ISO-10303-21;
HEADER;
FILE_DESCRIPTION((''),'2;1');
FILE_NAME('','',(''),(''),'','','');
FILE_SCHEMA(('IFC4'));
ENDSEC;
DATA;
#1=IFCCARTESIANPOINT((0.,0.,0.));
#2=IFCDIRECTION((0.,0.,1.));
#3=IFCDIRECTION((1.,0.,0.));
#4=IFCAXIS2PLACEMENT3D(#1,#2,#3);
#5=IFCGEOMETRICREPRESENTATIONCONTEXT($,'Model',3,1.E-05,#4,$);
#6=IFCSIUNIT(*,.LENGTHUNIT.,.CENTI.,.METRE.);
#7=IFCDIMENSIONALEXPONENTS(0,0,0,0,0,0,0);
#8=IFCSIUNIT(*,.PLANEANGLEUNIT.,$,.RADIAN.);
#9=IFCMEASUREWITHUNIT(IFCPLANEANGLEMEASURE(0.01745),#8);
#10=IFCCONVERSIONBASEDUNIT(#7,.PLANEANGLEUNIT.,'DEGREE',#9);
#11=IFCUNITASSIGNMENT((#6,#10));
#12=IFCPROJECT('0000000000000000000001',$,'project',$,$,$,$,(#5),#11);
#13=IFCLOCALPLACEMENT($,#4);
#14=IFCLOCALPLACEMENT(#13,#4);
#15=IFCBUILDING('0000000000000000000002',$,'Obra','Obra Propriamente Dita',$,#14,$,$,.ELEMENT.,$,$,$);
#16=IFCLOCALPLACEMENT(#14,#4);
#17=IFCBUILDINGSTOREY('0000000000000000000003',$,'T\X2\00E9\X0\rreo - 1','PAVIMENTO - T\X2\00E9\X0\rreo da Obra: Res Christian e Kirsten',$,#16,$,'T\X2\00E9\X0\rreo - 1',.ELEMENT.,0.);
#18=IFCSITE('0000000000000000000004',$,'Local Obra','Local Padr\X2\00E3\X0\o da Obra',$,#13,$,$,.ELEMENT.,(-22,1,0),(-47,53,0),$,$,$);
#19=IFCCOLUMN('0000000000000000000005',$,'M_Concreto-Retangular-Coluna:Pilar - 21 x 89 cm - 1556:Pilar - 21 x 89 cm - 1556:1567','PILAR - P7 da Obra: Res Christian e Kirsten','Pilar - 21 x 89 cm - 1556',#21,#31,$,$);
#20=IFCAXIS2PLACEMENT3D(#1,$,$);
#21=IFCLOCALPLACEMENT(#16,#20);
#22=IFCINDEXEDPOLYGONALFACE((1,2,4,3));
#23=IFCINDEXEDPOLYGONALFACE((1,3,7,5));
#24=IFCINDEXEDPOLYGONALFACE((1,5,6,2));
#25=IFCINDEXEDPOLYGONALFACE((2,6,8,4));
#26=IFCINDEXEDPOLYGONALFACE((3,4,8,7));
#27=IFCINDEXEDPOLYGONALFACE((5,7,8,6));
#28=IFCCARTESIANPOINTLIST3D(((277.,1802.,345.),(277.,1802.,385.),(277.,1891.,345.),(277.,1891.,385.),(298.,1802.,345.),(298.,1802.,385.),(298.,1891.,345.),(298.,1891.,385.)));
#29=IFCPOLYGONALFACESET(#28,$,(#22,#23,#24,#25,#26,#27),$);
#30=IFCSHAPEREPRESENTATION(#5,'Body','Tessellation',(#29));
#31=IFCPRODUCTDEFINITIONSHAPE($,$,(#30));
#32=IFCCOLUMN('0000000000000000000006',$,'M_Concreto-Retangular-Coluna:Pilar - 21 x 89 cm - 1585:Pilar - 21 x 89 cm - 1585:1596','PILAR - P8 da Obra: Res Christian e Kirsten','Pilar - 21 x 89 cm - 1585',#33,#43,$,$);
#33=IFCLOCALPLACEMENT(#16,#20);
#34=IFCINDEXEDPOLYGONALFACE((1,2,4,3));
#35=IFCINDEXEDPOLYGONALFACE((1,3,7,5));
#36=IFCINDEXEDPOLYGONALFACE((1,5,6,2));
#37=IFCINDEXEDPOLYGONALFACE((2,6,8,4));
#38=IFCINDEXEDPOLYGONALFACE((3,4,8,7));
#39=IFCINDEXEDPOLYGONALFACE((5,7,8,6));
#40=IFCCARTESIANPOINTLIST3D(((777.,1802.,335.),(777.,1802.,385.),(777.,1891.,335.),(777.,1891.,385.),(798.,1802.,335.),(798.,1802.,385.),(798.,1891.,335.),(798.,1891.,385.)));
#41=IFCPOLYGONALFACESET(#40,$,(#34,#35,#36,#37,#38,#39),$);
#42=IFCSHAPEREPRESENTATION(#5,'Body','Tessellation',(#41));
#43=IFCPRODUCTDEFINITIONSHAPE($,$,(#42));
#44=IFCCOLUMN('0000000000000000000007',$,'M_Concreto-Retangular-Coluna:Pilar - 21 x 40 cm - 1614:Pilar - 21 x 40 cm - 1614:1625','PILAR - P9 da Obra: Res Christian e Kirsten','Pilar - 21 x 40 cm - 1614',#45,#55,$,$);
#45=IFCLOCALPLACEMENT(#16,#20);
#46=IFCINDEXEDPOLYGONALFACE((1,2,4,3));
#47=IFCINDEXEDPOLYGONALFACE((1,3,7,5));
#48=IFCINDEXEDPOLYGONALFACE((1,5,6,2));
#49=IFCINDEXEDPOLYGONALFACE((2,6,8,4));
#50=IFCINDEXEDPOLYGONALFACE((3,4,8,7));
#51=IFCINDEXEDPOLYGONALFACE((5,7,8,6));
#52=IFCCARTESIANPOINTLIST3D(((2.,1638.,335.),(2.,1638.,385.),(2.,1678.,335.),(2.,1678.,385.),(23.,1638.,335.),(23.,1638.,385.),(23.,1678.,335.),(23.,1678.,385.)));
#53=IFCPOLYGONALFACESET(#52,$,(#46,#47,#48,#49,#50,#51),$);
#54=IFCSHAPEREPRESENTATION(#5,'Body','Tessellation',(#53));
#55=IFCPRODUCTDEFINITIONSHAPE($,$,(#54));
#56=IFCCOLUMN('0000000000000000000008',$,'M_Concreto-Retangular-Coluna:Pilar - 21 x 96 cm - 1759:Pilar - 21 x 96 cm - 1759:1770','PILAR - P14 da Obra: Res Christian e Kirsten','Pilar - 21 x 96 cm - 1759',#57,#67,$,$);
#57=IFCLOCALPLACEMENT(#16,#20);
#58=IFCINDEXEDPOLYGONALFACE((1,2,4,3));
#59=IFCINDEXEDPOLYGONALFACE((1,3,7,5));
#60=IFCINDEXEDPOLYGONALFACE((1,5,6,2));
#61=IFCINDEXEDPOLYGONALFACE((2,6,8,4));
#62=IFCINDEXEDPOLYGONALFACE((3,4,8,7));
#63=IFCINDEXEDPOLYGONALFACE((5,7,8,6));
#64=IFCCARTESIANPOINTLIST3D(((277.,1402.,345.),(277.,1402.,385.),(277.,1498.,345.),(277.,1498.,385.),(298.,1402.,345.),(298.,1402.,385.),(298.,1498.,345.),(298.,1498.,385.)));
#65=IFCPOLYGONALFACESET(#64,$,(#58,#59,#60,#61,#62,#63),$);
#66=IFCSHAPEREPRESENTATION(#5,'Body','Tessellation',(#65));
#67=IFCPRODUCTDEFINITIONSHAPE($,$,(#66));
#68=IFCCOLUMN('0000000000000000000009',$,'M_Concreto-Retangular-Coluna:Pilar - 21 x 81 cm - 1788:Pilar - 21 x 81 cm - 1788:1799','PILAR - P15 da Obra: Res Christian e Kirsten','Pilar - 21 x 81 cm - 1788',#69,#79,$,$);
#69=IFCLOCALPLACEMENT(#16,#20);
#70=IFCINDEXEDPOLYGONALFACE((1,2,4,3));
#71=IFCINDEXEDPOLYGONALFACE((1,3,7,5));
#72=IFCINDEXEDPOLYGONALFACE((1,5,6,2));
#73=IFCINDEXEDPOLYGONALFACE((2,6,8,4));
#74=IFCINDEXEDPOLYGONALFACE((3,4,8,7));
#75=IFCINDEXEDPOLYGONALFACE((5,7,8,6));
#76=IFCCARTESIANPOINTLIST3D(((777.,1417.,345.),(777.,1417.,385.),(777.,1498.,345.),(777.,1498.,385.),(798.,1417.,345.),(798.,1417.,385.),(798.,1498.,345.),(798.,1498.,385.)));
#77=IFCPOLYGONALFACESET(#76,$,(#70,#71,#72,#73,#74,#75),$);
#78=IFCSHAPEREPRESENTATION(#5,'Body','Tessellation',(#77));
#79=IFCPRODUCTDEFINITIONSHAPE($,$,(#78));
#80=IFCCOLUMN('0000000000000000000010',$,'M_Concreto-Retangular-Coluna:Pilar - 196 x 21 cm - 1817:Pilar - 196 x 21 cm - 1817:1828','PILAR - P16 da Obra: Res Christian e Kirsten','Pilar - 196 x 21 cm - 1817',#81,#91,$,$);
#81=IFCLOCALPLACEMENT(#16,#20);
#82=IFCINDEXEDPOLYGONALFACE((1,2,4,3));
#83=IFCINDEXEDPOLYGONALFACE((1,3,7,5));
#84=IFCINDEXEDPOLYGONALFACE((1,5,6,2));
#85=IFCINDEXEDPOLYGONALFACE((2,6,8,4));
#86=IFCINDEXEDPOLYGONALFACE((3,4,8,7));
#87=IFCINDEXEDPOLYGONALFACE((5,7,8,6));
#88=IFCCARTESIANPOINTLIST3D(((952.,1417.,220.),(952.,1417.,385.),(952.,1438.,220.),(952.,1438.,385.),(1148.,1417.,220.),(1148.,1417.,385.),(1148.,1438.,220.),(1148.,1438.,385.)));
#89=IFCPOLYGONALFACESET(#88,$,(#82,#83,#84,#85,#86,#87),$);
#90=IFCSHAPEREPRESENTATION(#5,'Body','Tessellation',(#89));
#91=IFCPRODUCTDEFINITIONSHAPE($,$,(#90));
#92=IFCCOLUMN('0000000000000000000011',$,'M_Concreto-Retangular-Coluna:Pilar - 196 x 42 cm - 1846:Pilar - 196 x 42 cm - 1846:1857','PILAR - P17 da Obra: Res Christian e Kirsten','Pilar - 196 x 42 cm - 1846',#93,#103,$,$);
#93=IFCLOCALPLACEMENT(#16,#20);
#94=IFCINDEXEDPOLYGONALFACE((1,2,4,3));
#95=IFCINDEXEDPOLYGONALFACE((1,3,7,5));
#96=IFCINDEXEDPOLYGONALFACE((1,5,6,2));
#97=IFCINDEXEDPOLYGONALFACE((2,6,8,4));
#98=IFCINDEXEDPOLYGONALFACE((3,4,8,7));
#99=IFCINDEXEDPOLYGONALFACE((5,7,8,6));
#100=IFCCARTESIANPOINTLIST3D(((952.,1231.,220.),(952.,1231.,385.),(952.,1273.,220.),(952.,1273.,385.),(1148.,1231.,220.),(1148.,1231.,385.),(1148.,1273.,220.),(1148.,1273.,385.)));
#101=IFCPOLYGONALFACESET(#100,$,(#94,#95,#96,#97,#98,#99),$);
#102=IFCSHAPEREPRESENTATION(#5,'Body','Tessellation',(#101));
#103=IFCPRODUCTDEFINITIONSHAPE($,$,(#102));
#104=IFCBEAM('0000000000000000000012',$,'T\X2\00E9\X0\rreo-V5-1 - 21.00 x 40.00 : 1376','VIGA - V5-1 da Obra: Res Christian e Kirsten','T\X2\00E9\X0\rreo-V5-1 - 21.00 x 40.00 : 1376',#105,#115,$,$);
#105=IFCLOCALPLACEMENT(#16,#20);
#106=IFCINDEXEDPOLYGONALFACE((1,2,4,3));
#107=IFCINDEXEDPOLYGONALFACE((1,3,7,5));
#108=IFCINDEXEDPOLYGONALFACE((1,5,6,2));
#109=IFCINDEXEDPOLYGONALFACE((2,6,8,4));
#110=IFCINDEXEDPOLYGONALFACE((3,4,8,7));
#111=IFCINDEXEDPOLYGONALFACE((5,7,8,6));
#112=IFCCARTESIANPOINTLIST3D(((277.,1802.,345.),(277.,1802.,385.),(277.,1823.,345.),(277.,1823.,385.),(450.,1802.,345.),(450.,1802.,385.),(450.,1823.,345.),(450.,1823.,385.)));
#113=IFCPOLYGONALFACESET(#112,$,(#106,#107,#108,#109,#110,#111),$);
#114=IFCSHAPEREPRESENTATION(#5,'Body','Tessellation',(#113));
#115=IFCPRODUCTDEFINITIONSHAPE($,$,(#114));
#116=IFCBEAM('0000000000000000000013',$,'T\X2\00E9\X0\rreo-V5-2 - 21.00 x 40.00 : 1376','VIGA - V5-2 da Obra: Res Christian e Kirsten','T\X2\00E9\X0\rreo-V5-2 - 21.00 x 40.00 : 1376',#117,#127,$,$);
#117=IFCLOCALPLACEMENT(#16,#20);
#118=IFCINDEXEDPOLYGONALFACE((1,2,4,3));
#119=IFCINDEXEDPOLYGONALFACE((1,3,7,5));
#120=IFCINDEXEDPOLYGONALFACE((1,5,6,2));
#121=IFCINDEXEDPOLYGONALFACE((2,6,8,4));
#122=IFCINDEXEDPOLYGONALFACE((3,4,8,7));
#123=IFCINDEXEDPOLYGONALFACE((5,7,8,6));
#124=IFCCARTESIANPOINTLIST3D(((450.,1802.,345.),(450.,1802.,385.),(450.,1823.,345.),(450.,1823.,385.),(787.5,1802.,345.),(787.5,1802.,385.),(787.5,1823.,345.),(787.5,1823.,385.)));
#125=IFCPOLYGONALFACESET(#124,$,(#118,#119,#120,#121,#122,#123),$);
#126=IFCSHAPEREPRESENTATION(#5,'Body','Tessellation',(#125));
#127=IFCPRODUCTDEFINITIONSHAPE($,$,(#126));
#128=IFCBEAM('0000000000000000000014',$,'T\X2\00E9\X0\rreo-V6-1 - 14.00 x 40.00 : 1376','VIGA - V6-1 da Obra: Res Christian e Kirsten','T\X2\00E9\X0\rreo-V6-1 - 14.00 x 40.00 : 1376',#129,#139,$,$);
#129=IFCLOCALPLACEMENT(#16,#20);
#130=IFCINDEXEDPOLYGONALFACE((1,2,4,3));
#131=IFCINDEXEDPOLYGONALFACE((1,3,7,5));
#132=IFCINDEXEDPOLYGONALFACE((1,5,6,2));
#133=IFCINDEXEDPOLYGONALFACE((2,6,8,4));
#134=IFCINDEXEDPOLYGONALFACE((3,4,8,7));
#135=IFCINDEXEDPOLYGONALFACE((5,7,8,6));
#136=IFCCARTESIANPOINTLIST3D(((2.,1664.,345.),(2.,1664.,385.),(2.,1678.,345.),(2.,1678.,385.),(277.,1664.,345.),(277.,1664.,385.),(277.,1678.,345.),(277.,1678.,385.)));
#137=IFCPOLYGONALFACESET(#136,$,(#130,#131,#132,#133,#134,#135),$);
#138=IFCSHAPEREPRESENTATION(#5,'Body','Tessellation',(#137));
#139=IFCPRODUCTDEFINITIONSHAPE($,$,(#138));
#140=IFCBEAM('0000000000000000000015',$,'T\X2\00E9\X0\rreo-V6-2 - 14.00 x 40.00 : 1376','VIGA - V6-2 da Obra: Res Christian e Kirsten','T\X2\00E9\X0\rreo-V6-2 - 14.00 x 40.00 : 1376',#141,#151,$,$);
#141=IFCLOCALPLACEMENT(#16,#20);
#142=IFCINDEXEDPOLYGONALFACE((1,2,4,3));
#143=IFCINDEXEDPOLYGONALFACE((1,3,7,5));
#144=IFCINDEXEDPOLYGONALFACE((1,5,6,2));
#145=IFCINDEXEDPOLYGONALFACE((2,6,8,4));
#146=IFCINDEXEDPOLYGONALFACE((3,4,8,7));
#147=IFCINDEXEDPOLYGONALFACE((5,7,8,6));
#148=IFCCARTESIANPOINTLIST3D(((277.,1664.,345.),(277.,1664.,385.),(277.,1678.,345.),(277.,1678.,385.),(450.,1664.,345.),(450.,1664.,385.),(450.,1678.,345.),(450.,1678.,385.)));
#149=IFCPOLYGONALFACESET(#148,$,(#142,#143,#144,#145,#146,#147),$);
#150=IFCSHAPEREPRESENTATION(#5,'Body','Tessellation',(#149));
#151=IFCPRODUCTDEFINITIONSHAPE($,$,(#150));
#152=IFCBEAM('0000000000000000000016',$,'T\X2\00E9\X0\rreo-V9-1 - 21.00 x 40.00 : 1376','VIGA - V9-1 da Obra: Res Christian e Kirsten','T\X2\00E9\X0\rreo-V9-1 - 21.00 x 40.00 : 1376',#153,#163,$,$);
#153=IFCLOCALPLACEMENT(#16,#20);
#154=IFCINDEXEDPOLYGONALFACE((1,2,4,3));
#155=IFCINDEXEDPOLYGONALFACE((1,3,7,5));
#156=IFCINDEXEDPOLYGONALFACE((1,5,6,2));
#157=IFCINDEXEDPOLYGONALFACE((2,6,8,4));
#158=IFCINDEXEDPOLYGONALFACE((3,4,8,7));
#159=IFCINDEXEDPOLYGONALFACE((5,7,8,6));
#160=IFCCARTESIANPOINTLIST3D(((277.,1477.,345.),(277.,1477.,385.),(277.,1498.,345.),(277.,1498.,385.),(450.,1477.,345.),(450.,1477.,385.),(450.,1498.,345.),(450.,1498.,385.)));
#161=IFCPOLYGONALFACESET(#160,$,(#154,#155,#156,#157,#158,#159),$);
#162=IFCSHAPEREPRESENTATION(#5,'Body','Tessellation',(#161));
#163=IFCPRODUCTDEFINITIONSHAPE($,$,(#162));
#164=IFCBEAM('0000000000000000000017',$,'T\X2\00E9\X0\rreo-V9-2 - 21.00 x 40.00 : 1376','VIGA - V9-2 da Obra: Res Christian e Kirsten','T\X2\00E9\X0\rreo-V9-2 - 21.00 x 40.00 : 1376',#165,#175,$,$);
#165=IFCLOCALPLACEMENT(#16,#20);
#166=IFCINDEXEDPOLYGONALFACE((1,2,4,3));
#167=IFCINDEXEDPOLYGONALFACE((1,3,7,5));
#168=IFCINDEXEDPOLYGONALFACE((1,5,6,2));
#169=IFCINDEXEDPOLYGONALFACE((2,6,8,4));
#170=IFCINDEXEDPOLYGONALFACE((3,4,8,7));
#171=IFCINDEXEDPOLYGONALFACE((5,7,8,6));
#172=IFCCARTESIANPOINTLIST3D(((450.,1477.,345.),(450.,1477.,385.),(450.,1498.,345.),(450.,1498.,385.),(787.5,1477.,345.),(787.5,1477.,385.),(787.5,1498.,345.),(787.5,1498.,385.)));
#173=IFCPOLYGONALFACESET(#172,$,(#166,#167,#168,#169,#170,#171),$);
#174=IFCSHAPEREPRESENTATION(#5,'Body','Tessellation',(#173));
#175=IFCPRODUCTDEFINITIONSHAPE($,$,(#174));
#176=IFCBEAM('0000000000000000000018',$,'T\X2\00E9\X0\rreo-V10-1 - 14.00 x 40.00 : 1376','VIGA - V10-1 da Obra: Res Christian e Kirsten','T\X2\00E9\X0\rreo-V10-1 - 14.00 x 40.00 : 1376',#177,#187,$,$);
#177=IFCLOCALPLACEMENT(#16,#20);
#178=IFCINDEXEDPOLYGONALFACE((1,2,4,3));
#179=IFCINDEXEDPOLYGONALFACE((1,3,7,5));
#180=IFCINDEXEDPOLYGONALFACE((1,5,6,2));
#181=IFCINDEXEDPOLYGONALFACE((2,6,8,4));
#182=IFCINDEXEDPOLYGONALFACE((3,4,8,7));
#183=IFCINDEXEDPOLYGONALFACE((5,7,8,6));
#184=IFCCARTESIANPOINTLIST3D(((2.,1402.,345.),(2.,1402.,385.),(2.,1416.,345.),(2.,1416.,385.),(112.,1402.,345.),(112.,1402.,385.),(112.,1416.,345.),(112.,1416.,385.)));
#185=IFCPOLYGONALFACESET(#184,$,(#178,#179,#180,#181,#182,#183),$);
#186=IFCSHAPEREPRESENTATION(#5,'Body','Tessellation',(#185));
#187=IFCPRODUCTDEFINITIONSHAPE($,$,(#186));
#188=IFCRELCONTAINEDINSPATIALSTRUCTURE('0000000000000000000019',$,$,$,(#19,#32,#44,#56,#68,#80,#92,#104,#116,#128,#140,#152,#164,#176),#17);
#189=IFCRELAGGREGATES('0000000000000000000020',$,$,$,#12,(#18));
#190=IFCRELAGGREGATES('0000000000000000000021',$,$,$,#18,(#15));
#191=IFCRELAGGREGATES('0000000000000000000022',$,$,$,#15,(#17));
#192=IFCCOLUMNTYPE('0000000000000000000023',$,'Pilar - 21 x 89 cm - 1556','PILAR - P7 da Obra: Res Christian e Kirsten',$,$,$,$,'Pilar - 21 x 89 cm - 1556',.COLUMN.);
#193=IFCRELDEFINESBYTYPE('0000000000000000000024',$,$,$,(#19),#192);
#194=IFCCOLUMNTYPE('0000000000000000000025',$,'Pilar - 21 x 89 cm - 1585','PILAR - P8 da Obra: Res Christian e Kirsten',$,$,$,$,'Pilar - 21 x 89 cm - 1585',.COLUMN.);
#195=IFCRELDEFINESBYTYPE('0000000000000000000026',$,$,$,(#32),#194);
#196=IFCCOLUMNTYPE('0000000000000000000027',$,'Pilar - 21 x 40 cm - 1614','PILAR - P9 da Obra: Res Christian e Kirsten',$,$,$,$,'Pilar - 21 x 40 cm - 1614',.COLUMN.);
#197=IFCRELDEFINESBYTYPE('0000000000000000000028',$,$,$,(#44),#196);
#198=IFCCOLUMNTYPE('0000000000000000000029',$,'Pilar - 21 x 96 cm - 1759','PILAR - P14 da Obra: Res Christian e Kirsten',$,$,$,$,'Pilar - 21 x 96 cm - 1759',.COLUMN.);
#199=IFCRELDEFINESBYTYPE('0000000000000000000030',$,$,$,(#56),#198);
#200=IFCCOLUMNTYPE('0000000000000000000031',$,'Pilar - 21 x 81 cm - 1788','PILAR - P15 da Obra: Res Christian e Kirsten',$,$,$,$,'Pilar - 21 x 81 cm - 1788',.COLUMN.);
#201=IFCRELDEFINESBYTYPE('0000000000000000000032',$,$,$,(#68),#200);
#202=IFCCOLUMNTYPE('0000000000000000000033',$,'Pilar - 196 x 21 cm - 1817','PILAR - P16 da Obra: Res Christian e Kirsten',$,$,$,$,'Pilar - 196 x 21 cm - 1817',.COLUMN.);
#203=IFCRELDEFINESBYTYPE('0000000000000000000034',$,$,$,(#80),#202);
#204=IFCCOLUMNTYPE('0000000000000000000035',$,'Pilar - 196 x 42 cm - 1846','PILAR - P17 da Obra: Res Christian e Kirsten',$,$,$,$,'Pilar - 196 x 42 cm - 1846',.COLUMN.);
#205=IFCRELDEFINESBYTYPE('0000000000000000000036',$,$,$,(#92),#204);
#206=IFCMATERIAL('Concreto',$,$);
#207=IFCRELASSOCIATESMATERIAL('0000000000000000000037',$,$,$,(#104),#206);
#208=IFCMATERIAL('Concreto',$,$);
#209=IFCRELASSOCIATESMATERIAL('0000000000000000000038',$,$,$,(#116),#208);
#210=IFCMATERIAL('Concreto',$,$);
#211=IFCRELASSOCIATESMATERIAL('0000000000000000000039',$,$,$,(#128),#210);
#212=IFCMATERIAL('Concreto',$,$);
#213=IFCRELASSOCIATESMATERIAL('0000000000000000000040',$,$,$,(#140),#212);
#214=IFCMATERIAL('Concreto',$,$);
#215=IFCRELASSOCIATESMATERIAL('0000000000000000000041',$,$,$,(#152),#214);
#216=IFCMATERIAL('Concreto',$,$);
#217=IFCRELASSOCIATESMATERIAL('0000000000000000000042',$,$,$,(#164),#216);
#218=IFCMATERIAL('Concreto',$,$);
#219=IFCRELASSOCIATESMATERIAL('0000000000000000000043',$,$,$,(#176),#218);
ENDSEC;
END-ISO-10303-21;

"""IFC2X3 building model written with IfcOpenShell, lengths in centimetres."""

from ifc_helpers import new_model, entity, si_unit, converted_unit, frame, origin, origin_with_axes, origin_2d_with_axis, place, context, project, spatial, polyline, rectangle, outline, extrude, source, transform, mapped, material, type_object, type_shapes, element, save


model = new_model("IFC2X3")

# Units and contexts
model_context = context("Model", 3, precision=1e-05, world=origin_with_axes())
ifc_project = project(units=[si_unit("LENGTHUNIT", "METRE", prefix="CENTI"), converted_unit("PLANEANGLEUNIT", "DEGREE", entity("IfcPlaneAngleMeasure", 0.01745), si_unit("PLANEANGLEUNIT", "RADIAN"), dimensions=[0, 0, 0, 0, 0, 0, 0])], contexts=[model_context])

# Site, building, storey
site_placement = place(None, origin_with_axes())
site = spatial("IfcSite", under=ifc_project, at=site_placement, Name="Local Obra", Description="Local Padrão da Obra", CompositionType="ELEMENT", RefLatitude=(-22, 1, 0), RefLongitude=(-47, 53, 0))
building_placement = place(site_placement, origin_with_axes())
building = spatial("IfcBuilding", under=site, at=building_placement, Name="Obra", Description="Obra Propriamente Dita", CompositionType="ELEMENT")
storey_placement = place(building_placement, origin_with_axes())
storey = spatial("IfcBuildingStorey", under=building, at=storey_placement, Name="Térreo - 1", Description="PAVIMENTO - Térreo da Obra: Res Christian e Kirsten", LongName="Térreo - 1", CompositionType="ELEMENT", Elevation=0.0)

# Columns
column_type_1 = type_object("IfcColumnType", Name="Pilar - 21 x 89 cm - 1556", Description="PILAR - P7 da Obra: Res Christian e Kirsten", ElementType="Pilar - 21 x 89 cm - 1556", PredefinedType="COLUMN")
shared_shape_1 = source(origin(), model_context, "Body", "SweptSolid", [
    extrude(rectangle(XDim=21.0, YDim=89.0, at=origin_2d_with_axis()), origin(), (0.0, 0.0, 1.0), 40.0),
])
type_shapes(column_type_1, [shared_shape_1])
column_1_placement = place(storey_placement, frame((287.5, 1846.5, 345.0), z_axis=(0.0, 0.0, 1.0), x_axis=(1.0, 0.0, 0.0)))
element("IfcColumn", 1, at=column_1_placement, inside=storey, type_object=column_type_1, Name="M_Concreto-Retangular-Coluna:Pilar - 21 x 89 cm - 1556:Pilar - 21 x 89 cm - 1556:1567", Description="PILAR - P7 da Obra: Res Christian e Kirsten", ObjectType="Pilar - 21 x 89 cm - 1556", context=model_context, shape_type="MappedRepresentation", body=[
    mapped(shared_shape_1, transform((0.0, 0.0, 0.0), scale=1.0)),
])
column_type_2 = type_object("IfcColumnType", Name="Pilar - 21 x 89 cm - 1585", Description="PILAR - P8 da Obra: Res Christian e Kirsten", ElementType="Pilar - 21 x 89 cm - 1585", PredefinedType="COLUMN")
shared_shape_2 = source(origin(), model_context, "Body", "SweptSolid", [
    extrude(rectangle(XDim=21.0, YDim=89.0, at=origin_2d_with_axis()), origin(), (0.0, 0.0, 1.0), 50.0),
])
type_shapes(column_type_2, [shared_shape_2])
column_2_placement = place(storey_placement, frame((787.5, 1846.5, 335.0), z_axis=(0.0, 0.0, 1.0), x_axis=(1.0, 0.0, 0.0)))
element("IfcColumn", 2, at=column_2_placement, inside=storey, type_object=column_type_2, Name="M_Concreto-Retangular-Coluna:Pilar - 21 x 89 cm - 1585:Pilar - 21 x 89 cm - 1585:1596", Description="PILAR - P8 da Obra: Res Christian e Kirsten", ObjectType="Pilar - 21 x 89 cm - 1585", context=model_context, shape_type="MappedRepresentation", body=[
    mapped(shared_shape_2, transform((0.0, 0.0, 0.0), scale=1.0)),
])
column_type_3 = type_object("IfcColumnType", Name="Pilar - 21 x 40 cm - 1614", Description="PILAR - P9 da Obra: Res Christian e Kirsten", ElementType="Pilar - 21 x 40 cm - 1614", PredefinedType="COLUMN")
shared_shape_3 = source(origin(), model_context, "Body", "SweptSolid", [
    extrude(rectangle(XDim=21.0, YDim=40.0, at=origin_2d_with_axis()), origin(), (0.0, 0.0, 1.0), 50.0),
])
type_shapes(column_type_3, [shared_shape_3])
column_3_placement = place(storey_placement, frame((12.5, 1658.0, 335.0), z_axis=(0.0, 0.0, 1.0), x_axis=(1.0, 0.0, 0.0)))
element("IfcColumn", 3, at=column_3_placement, inside=storey, type_object=column_type_3, Name="M_Concreto-Retangular-Coluna:Pilar - 21 x 40 cm - 1614:Pilar - 21 x 40 cm - 1614:1625", Description="PILAR - P9 da Obra: Res Christian e Kirsten", ObjectType="Pilar - 21 x 40 cm - 1614", context=model_context, shape_type="MappedRepresentation", body=[
    mapped(shared_shape_3, transform((0.0, 0.0, 0.0), scale=1.0)),
])
column_type_4 = type_object("IfcColumnType", Name="Pilar - 21 x 96 cm - 1759", Description="PILAR - P14 da Obra: Res Christian e Kirsten", ElementType="Pilar - 21 x 96 cm - 1759", PredefinedType="COLUMN")
shared_shape_4 = source(origin(), model_context, "Body", "SweptSolid", [
    extrude(rectangle(XDim=21.0, YDim=96.0, at=origin_2d_with_axis()), origin(), (0.0, 0.0, 1.0), 40.0),
])
type_shapes(column_type_4, [shared_shape_4])
column_4_placement = place(storey_placement, frame((287.5, 1450.0, 345.0), z_axis=(0.0, 0.0, 1.0), x_axis=(1.0, 0.0, 0.0)))
element("IfcColumn", 4, at=column_4_placement, inside=storey, type_object=column_type_4, Name="M_Concreto-Retangular-Coluna:Pilar - 21 x 96 cm - 1759:Pilar - 21 x 96 cm - 1759:1770", Description="PILAR - P14 da Obra: Res Christian e Kirsten", ObjectType="Pilar - 21 x 96 cm - 1759", context=model_context, shape_type="MappedRepresentation", body=[
    mapped(shared_shape_4, transform((0.0, 0.0, 0.0), scale=1.0)),
])
column_type_5 = type_object("IfcColumnType", Name="Pilar - 21 x 81 cm - 1788", Description="PILAR - P15 da Obra: Res Christian e Kirsten", ElementType="Pilar - 21 x 81 cm - 1788", PredefinedType="COLUMN")
shared_shape_5 = source(origin(), model_context, "Body", "SweptSolid", [
    extrude(rectangle(XDim=21.0, YDim=81.0, at=origin_2d_with_axis()), origin(), (0.0, 0.0, 1.0), 40.0),
])
type_shapes(column_type_5, [shared_shape_5])
column_5_placement = place(storey_placement, frame((787.5, 1457.5, 345.0), z_axis=(0.0, 0.0, 1.0), x_axis=(1.0, 0.0, 0.0)))
element("IfcColumn", 5, at=column_5_placement, inside=storey, type_object=column_type_5, Name="M_Concreto-Retangular-Coluna:Pilar - 21 x 81 cm - 1788:Pilar - 21 x 81 cm - 1788:1799", Description="PILAR - P15 da Obra: Res Christian e Kirsten", ObjectType="Pilar - 21 x 81 cm - 1788", context=model_context, shape_type="MappedRepresentation", body=[
    mapped(shared_shape_5, transform((0.0, 0.0, 0.0), scale=1.0)),
])
column_type_6 = type_object("IfcColumnType", Name="Pilar - 196 x 21 cm - 1817", Description="PILAR - P16 da Obra: Res Christian e Kirsten", ElementType="Pilar - 196 x 21 cm - 1817", PredefinedType="COLUMN")
shared_shape_6 = source(origin(), model_context, "Body", "SweptSolid", [
    extrude(rectangle(XDim=196.0, YDim=21.0, at=origin_2d_with_axis()), origin(), (0.0, 0.0, 1.0), 165.0),
])
type_shapes(column_type_6, [shared_shape_6])
column_6_placement = place(storey_placement, frame((1050.0, 1427.5, 220.0), z_axis=(0.0, 0.0, 1.0), x_axis=(1.0, 0.0, 0.0)))
element("IfcColumn", 6, at=column_6_placement, inside=storey, type_object=column_type_6, Name="M_Concreto-Retangular-Coluna:Pilar - 196 x 21 cm - 1817:Pilar - 196 x 21 cm - 1817:1828", Description="PILAR - P16 da Obra: Res Christian e Kirsten", ObjectType="Pilar - 196 x 21 cm - 1817", context=model_context, shape_type="MappedRepresentation", body=[
    mapped(shared_shape_6, transform((0.0, 0.0, 0.0), scale=1.0)),
])
column_type_7 = type_object("IfcColumnType", Name="Pilar - 196 x 42 cm - 1846", Description="PILAR - P17 da Obra: Res Christian e Kirsten", ElementType="Pilar - 196 x 42 cm - 1846", PredefinedType="COLUMN")
shared_shape_7 = source(origin(), model_context, "Body", "SweptSolid", [
    extrude(rectangle(XDim=196.0, YDim=42.0, at=origin_2d_with_axis()), origin(), (0.0, 0.0, 1.0), 165.0),
])
type_shapes(column_type_7, [shared_shape_7])
column_7_placement = place(storey_placement, frame((1050.0, 1252.0, 220.0), z_axis=(0.0, 0.0, 1.0), x_axis=(1.0, 0.0, 0.0)))
element("IfcColumn", 7, at=column_7_placement, inside=storey, type_object=column_type_7, Name="M_Concreto-Retangular-Coluna:Pilar - 196 x 42 cm - 1846:Pilar - 196 x 42 cm - 1846:1857", Description="PILAR - P17 da Obra: Res Christian e Kirsten", ObjectType="Pilar - 196 x 42 cm - 1846", context=model_context, shape_type="MappedRepresentation", body=[
    mapped(shared_shape_7, transform((0.0, 0.0, 0.0), scale=1.0)),
])

# Beams
ifc_material_1 = material(Name="Concreto")
beam_1_placement = place(storey_placement, frame((277.0, 1802.0, 385.0), z_axis=(1.0, 0.0, 0.0), x_axis=(0.0, -1.0, 0.0)))
element("IfcBeam", 8, at=beam_1_placement, inside=storey, material=ifc_material_1, Name="Térreo-V5-1 - 21.00 x 40.00 : 1376", Description="VIGA - V5-1 da Obra: Res Christian e Kirsten", ObjectType="Térreo-V5-1 - 21.00 x 40.00 : 1376", context=model_context, shape_type="SweptSolid", body=[
    extrude(outline(polyline([(-21.0, 0.0), (0.0, 0.0), (0.0, 40.0), (-21.0, 40.0), (-21.0, 0.0)])), origin_with_axes(), (0.0, 0.0, 1.0), 173.0),
])
ifc_material_2 = material(Name="Concreto")
beam_2_placement = place(storey_placement, frame((450.0, 1802.0, 385.0), z_axis=(1.0, 0.0, 0.0), x_axis=(0.0, -1.0, 0.0)))
element("IfcBeam", 9, at=beam_2_placement, inside=storey, material=ifc_material_2, Name="Térreo-V5-2 - 21.00 x 40.00 : 1376", Description="VIGA - V5-2 da Obra: Res Christian e Kirsten", ObjectType="Térreo-V5-2 - 21.00 x 40.00 : 1376", context=model_context, shape_type="SweptSolid", body=[
    extrude(outline(polyline([(-21.0, 0.0), (0.0, 0.0), (0.0, 40.0), (-21.0, 40.0), (-21.0, 0.0)])), origin_with_axes(), (0.0, 0.0, 1.0), 337.5),
])
ifc_material_3 = material(Name="Concreto")
beam_3_placement = place(storey_placement, frame((2.0, 1678.0, 385.0), z_axis=(1.0, 0.0, 0.0), x_axis=(0.0, -1.0, 0.0)))
element("IfcBeam", 10, at=beam_3_placement, inside=storey, material=ifc_material_3, Name="Térreo-V6-1 - 14.00 x 40.00 : 1376", Description="VIGA - V6-1 da Obra: Res Christian e Kirsten", ObjectType="Térreo-V6-1 - 14.00 x 40.00 : 1376", context=model_context, shape_type="SweptSolid", body=[
    extrude(outline(polyline([(0.0, 0.0), (14.0, 0.0), (14.0, 40.0), (0.0, 40.0), (0.0, 0.0)])), origin_with_axes(), (0.0, 0.0, 1.0), 275.0),
])
ifc_material_4 = material(Name="Concreto")
beam_4_placement = place(storey_placement, frame((277.0, 1678.0, 385.0), z_axis=(1.0, 0.0, 0.0), x_axis=(0.0, -1.0, 0.0)))
element("IfcBeam", 11, at=beam_4_placement, inside=storey, material=ifc_material_4, Name="Térreo-V6-2 - 14.00 x 40.00 : 1376", Description="VIGA - V6-2 da Obra: Res Christian e Kirsten", ObjectType="Térreo-V6-2 - 14.00 x 40.00 : 1376", context=model_context, shape_type="SweptSolid", body=[
    extrude(outline(polyline([(0.0, 0.0), (14.0, 0.0), (14.0, 40.0), (0.0, 40.0), (0.0, 0.0)])), origin_with_axes(), (0.0, 0.0, 1.0), 173.0),
])
ifc_material_5 = material(Name="Concreto")
beam_5_placement = place(storey_placement, frame((277.0, 1498.0, 385.0), z_axis=(1.0, 0.0, 0.0), x_axis=(0.0, -1.0, 0.0)))
element("IfcBeam", 12, at=beam_5_placement, inside=storey, material=ifc_material_5, Name="Térreo-V9-1 - 21.00 x 40.00 : 1376", Description="VIGA - V9-1 da Obra: Res Christian e Kirsten", ObjectType="Térreo-V9-1 - 21.00 x 40.00 : 1376", context=model_context, shape_type="SweptSolid", body=[
    extrude(outline(polyline([(0.0, 0.0), (21.0, 0.0), (21.0, 40.0), (0.0, 40.0), (0.0, 0.0)])), origin_with_axes(), (0.0, 0.0, 1.0), 173.0),
])
ifc_material_6 = material(Name="Concreto")
beam_6_placement = place(storey_placement, frame((450.0, 1498.0, 385.0), z_axis=(1.0, 0.0, 0.0), x_axis=(0.0, -1.0, 0.0)))
element("IfcBeam", 13, at=beam_6_placement, inside=storey, material=ifc_material_6, Name="Térreo-V9-2 - 21.00 x 40.00 : 1376", Description="VIGA - V9-2 da Obra: Res Christian e Kirsten", ObjectType="Térreo-V9-2 - 21.00 x 40.00 : 1376", context=model_context, shape_type="SweptSolid", body=[
    extrude(outline(polyline([(0.0, 0.0), (21.0, 0.0), (21.0, 40.0), (0.0, 40.0), (0.0, 0.0)])), origin_with_axes(), (0.0, 0.0, 1.0), 337.5),
])
ifc_material_7 = material(Name="Concreto")
beam_7_placement = place(storey_placement, frame((2.0, 1402.0, 385.0), z_axis=(1.0, 0.0, 0.0), x_axis=(0.0, -1.0, 0.0)))
element("IfcBeam", 14, at=beam_7_placement, inside=storey, material=ifc_material_7, Name="Térreo-V10-1 - 14.00 x 40.00 : 1376", Description="VIGA - V10-1 da Obra: Res Christian e Kirsten", ObjectType="Térreo-V10-1 - 14.00 x 40.00 : 1376", context=model_context, shape_type="SweptSolid", body=[
    extrude(outline(polyline([(-14.0, 0.0), (0.0, 0.0), (0.0, 40.0), (-14.0, 40.0), (-14.0, 0.0)])), origin_with_axes(), (0.0, 0.0, 1.0), 110.0),
])

save(model, "model.ifc")
